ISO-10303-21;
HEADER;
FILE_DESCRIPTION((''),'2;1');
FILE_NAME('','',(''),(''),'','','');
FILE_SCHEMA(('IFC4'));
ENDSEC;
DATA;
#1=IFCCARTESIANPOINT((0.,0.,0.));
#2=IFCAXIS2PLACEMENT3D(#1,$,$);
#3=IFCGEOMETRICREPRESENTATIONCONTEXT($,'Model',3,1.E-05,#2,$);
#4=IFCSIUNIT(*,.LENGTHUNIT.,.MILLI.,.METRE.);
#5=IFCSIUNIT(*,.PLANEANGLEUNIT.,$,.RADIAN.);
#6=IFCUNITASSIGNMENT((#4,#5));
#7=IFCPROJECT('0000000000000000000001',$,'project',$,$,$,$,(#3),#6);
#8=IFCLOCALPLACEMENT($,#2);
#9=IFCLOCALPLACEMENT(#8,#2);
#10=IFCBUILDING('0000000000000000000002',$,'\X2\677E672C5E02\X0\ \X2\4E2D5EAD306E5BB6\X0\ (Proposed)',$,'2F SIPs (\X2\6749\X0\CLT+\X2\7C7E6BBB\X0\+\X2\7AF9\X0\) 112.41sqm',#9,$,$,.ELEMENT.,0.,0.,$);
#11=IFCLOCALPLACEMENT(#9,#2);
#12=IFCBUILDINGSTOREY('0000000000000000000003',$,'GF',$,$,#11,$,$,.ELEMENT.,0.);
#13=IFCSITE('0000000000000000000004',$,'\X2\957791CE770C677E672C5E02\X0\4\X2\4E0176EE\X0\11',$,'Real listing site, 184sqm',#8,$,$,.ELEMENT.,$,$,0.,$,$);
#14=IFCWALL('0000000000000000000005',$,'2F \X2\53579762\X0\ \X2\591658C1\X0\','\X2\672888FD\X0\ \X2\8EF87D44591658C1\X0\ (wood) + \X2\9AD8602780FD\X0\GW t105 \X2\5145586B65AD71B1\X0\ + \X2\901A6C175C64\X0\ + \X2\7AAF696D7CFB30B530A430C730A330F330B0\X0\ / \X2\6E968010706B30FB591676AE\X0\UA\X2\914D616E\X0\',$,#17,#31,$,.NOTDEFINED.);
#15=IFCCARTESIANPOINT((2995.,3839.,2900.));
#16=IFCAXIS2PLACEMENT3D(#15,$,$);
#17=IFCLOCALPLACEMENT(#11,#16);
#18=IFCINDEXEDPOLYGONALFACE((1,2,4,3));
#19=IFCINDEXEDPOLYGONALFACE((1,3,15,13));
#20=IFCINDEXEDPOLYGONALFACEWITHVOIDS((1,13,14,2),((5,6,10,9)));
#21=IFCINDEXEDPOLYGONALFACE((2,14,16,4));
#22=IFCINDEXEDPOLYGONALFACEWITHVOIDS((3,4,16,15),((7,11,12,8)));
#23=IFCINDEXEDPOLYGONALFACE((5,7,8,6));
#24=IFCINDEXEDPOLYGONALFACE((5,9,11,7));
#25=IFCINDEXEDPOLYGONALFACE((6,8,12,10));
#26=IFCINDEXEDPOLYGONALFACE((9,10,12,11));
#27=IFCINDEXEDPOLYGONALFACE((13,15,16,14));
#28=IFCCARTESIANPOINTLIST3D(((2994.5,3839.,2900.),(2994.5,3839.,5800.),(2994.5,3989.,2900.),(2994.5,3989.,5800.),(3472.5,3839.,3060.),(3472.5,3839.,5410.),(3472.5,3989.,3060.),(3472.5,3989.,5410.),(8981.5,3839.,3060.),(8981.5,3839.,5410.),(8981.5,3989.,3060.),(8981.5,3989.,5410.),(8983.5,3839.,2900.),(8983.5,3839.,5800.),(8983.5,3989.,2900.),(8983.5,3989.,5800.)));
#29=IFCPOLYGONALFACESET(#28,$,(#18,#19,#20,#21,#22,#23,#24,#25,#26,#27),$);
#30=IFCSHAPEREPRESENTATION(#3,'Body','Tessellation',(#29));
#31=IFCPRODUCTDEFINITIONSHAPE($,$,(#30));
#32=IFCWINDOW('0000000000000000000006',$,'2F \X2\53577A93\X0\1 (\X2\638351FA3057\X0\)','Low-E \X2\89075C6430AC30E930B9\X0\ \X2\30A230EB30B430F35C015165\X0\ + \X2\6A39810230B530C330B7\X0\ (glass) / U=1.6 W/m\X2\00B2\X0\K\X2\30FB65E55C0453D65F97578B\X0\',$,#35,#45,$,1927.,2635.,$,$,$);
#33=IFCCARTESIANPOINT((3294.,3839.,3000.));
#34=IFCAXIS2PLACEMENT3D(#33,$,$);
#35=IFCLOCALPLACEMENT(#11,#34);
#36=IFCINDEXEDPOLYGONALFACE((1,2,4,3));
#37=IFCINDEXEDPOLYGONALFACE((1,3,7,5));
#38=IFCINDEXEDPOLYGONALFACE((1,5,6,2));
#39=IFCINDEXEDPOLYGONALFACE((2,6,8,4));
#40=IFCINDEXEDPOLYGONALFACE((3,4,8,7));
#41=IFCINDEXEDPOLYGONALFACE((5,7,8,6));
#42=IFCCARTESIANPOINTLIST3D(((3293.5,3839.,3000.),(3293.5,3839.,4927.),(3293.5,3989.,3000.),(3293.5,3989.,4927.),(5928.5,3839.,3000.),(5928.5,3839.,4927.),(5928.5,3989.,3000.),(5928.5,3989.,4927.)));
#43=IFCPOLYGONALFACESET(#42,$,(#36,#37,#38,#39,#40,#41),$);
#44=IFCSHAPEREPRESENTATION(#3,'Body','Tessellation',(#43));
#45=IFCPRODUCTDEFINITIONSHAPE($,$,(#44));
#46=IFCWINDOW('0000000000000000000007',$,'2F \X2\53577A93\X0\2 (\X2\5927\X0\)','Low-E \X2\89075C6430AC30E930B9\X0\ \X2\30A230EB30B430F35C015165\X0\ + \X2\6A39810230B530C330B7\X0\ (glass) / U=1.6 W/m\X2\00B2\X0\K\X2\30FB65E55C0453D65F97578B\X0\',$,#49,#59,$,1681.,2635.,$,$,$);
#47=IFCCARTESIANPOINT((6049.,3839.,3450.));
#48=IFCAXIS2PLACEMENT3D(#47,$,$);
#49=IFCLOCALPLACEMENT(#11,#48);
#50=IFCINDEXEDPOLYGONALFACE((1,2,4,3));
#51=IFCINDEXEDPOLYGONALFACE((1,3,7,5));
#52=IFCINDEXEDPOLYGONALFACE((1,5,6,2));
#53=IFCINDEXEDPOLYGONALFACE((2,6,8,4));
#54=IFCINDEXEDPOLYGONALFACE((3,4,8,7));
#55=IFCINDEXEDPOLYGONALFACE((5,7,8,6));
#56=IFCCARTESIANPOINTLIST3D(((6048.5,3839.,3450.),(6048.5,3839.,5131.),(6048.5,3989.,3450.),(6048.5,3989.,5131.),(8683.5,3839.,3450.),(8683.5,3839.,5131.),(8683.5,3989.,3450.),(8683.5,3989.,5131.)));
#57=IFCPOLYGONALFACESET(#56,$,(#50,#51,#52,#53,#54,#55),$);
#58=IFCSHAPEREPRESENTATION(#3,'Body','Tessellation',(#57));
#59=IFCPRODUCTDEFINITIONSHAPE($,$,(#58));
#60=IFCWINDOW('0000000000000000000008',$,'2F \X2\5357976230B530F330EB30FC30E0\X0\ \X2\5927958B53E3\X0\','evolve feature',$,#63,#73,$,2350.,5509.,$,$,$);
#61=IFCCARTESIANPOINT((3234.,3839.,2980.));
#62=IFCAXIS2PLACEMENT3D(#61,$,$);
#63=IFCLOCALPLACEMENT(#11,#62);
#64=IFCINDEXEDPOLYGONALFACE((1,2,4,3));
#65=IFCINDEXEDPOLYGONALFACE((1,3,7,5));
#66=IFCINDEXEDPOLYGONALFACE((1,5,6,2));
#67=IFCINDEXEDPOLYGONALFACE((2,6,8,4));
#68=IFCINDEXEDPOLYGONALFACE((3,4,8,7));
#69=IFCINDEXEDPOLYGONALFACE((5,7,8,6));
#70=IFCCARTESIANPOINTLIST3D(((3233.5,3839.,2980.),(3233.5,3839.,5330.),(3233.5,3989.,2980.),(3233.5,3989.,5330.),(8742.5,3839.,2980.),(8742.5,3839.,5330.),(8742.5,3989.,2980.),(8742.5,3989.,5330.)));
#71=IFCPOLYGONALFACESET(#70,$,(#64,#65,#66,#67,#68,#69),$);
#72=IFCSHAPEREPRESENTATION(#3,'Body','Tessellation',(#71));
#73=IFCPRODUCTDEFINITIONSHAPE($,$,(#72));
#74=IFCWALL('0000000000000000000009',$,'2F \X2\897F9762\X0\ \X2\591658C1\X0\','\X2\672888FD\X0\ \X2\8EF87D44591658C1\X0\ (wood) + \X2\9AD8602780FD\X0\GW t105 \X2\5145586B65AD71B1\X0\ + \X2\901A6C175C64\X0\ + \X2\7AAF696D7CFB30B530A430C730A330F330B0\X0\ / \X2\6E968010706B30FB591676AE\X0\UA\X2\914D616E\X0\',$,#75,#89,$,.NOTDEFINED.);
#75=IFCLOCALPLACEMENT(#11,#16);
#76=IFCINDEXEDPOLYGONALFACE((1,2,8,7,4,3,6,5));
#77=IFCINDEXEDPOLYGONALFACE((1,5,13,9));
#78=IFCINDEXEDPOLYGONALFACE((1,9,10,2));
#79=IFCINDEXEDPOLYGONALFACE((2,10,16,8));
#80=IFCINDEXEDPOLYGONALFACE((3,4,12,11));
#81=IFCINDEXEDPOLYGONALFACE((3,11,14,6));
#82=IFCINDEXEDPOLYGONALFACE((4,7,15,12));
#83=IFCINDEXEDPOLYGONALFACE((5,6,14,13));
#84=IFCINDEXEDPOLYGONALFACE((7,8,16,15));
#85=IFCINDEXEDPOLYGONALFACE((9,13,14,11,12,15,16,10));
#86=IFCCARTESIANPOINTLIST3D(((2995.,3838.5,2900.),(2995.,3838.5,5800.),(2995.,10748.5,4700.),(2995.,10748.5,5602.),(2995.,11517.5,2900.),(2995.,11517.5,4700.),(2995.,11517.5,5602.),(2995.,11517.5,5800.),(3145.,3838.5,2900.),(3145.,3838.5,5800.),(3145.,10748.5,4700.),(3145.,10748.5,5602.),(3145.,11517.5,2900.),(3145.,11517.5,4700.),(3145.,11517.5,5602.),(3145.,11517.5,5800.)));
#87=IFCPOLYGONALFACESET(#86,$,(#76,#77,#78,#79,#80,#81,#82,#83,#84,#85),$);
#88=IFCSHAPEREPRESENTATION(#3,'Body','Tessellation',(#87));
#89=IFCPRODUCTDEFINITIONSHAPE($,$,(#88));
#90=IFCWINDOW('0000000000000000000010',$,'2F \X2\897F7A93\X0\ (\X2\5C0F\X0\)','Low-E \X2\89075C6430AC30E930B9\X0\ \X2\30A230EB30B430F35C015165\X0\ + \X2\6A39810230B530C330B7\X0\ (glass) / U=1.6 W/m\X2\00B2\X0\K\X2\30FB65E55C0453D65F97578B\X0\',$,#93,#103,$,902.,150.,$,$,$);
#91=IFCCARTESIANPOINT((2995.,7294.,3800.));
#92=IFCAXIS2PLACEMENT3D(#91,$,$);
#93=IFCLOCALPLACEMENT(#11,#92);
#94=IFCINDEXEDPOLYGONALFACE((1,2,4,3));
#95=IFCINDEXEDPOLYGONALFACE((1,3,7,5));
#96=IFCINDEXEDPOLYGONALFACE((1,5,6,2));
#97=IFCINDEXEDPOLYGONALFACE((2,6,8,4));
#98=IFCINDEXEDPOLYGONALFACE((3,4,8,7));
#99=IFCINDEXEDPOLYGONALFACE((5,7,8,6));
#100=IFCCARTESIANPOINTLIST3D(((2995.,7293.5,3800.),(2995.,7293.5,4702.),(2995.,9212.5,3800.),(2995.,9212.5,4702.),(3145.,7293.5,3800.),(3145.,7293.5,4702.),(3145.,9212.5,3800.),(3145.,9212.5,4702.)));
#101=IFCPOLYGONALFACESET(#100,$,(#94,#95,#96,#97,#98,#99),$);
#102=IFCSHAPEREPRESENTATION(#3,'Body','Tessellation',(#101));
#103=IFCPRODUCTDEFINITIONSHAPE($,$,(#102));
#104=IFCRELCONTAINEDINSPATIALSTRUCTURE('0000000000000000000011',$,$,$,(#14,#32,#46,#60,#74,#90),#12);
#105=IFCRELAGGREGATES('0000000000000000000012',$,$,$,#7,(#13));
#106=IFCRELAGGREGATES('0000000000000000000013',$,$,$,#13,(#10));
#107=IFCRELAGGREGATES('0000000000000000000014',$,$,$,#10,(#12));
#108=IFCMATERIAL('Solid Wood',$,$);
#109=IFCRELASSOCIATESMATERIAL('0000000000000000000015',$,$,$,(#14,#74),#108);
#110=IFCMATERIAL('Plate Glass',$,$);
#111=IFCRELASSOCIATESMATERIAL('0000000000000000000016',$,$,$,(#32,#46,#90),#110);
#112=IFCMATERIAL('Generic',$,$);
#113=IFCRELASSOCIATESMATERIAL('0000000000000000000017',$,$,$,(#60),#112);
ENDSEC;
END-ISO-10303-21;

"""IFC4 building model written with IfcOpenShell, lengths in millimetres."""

from ifc_helpers import new_model, si_unit, frame, frame_2d, origin, place, context, project, spatial, rectangle, extrude, material, element, fill, save


model = new_model("IFC4")

# Units and contexts
model_context = context("Model", 3, precision=1e-05, world=origin())
ifc_project = project(units=[si_unit("LENGTHUNIT", "METRE", prefix="MILLI"), si_unit("PLANEANGLEUNIT", "RADIAN")], contexts=[model_context])

# Site, building, storey
site_placement = place(None, origin())
site = spatial("IfcSite", under=ifc_project, at=site_placement, Name="長野県松本市4丁目11", ObjectType="Real listing site, 184sqm", CompositionType="ELEMENT", RefElevation=0.0)
building_placement = place(site_placement, origin())
building = spatial("IfcBuilding", under=site, at=building_placement, Name="松本市 中庭の家 (Proposed)", ObjectType="2F SIPs (杉CLT+籾殻+竹) 112.41sqm", CompositionType="ELEMENT", ElevationOfRefHeight=0.0, ElevationOfTerrain=0.0)
storey_placement = place(building_placement, origin())
storey = spatial("IfcBuildingStorey", under=building, at=storey_placement, Name="GF", CompositionType="ELEMENT", Elevation=0.0)

# Shared definitions
ifc_material_1 = material(Name="Solid Wood")

# Shared definitions
ifc_material_2 = material(Name="Plate Glass")
ifc_material_3 = material(Name="Generic")

# Wall, openings, windows
wall_1_placement = place(storey_placement, frame((2995.0, 3839.0, 2900.0)))
wall_1 = element("IfcWall", 1, at=wall_1_placement, inside=storey, material=ifc_material_1, Name="2F 南面 外壁", Description="木製 軸組外壁 (wood) + 高性能GW t105 充填断熱 + 通気層 + 窯業系サイディング / 準耐火・外皮UA配慮", PredefinedType="NOTDEFINED", context=model_context, shape_type="SweptSolid", body=[
    extrude(rectangle(XDim=5989.0, YDim=150.0, at=frame_2d((2994.0, 75.0))), frame((2995.0, 3839.0, 2900.0)), (0.0, 0.0, 1.0), 2900.0),
])
opening_1_placement = place(storey_placement, frame((3294.0, 3839.0, 3000.0)))
opening_1 = element("IfcOpeningElement", 2, at=opening_1_placement, cuts=wall_1, PredefinedType="NOTDEFINED", context=model_context, shape_type="SweptSolid", body=[
    extrude(rectangle(XDim=2635.0, YDim=150.0, at=frame_2d((1317.0, 75.0))), frame((3294.0, 3839.0, 3000.0)), (0.0, 0.0, 1.0), 1927.0),
])
opening_2_placement = place(storey_placement, frame((6049.0, 3839.0, 3450.0)))
opening_2 = element("IfcOpeningElement", 3, at=opening_2_placement, cuts=wall_1, PredefinedType="NOTDEFINED", context=model_context, shape_type="SweptSolid", body=[
    extrude(rectangle(XDim=2635.0, YDim=150.0, at=frame_2d((1317.0, 75.0))), frame((6049.0, 3839.0, 3450.0)), (0.0, 0.0, 1.0), 1681.0),
])
opening_3_placement = place(storey_placement, frame((3234.0, 3839.0, 2980.0)))
opening_3 = element("IfcOpeningElement", 4, at=opening_3_placement, cuts=wall_1, PredefinedType="NOTDEFINED", context=model_context, shape_type="SweptSolid", body=[
    extrude(rectangle(XDim=5509.0, YDim=150.0, at=frame_2d((2754.0, 75.0))), frame((3234.0, 3839.0, 2980.0)), (0.0, 0.0, 1.0), 2350.0),
])
window_1_placement = place(storey_placement, frame((3294.0, 3839.0, 3000.0)))
window_1 = element("IfcWindow", 5, at=window_1_placement, inside=storey, material=ifc_material_2, Name="2F 南窓1 (掃出し)", Description="Low-E 複層ガラス アルゴン封入 + 樹脂サッシ (glass) / U=1.6 W/m²K・日射取得型", OverallHeight=1927.0, OverallWidth=2635.0, context=model_context, shape_type="SweptSolid", body=[
    extrude(rectangle(XDim=2635.0, YDim=150.0, at=frame_2d((1317.0, 75.0))), frame((3294.0, 3839.0, 3000.0)), (0.0, 0.0, 1.0), 1927.0),
])
fill(opening_1, window_1)
window_2_placement = place(storey_placement, frame((6049.0, 3839.0, 3450.0)))
window_2 = element("IfcWindow", 6, at=window_2_placement, inside=storey, material=ifc_material_2, Name="2F 南窓2 (大)", Description="Low-E 複層ガラス アルゴン封入 + 樹脂サッシ (glass) / U=1.6 W/m²K・日射取得型", OverallHeight=1681.0, OverallWidth=2635.0, context=model_context, shape_type="SweptSolid", body=[
    extrude(rectangle(XDim=2635.0, YDim=150.0, at=frame_2d((1317.0, 75.0))), frame((6049.0, 3839.0, 3450.0)), (0.0, 0.0, 1.0), 1681.0),
])
fill(opening_2, window_2)
window_3_placement = place(storey_placement, frame((3234.0, 3839.0, 2980.0)))
window_3 = element("IfcWindow", 7, at=window_3_placement, inside=storey, material=ifc_material_3, Name="2F 南面サンルーム 大開口", Description="evolve feature", OverallHeight=2350.0, OverallWidth=5509.0, context=model_context, shape_type="SweptSolid", body=[
    extrude(rectangle(XDim=5509.0, YDim=150.0, at=frame_2d((2754.0, 75.0))), frame((3234.0, 3839.0, 2980.0)), (0.0, 0.0, 1.0), 2350.0),
])
fill(opening_3, window_3)

# Wall, opening, window
wall_2_placement = place(storey_placement, frame((2995.0, 3839.0, 2900.0)))
wall_2 = element("IfcWall", 8, at=wall_2_placement, inside=storey, material=ifc_material_1, Name="2F 西面 外壁", Description="木製 軸組外壁 (wood) + 高性能GW t105 充填断熱 + 通気層 + 窯業系サイディング / 準耐火・外皮UA配慮", PredefinedType="NOTDEFINED", context=model_context, shape_type="SweptSolid", body=[
    extrude(rectangle(XDim=150.0, YDim=7679.0, at=frame_2d((75.0, 3839.0))), frame((2995.0, 3839.0, 2900.0)), (0.0, 0.0, 1.0), 2900.0),
])
opening_4_placement = place(storey_placement, frame((2995.0, 7294.0, 3800.0)))
opening_4 = element("IfcOpeningElement", 9, at=opening_4_placement, cuts=wall_2, PredefinedType="NOTDEFINED", context=model_context, shape_type="SweptSolid", body=[
    extrude(rectangle(XDim=150.0, YDim=1919.0, at=frame_2d((75.0, 959.0))), frame((2995.0, 7294.0, 3800.0)), (0.0, 0.0, 1.0), 902.0),
])
window_4_placement = place(storey_placement, frame((2995.0, 7294.0, 3800.0)))
window_4 = element("IfcWindow", 10, at=window_4_placement, inside=storey, material=ifc_material_2, Name="2F 西窓 (小)", Description="Low-E 複層ガラス アルゴン封入 + 樹脂サッシ (glass) / U=1.6 W/m²K・日射取得型", OverallHeight=902.0, OverallWidth=150.0, context=model_context, shape_type="SweptSolid", body=[
    extrude(rectangle(XDim=150.0, YDim=1919.0, at=frame_2d((75.0, 959.0))), frame((2995.0, 7294.0, 3800.0)), (0.0, 0.0, 1.0), 902.0),
])
fill(opening_4, window_4)

save(model, "model.ifc")
